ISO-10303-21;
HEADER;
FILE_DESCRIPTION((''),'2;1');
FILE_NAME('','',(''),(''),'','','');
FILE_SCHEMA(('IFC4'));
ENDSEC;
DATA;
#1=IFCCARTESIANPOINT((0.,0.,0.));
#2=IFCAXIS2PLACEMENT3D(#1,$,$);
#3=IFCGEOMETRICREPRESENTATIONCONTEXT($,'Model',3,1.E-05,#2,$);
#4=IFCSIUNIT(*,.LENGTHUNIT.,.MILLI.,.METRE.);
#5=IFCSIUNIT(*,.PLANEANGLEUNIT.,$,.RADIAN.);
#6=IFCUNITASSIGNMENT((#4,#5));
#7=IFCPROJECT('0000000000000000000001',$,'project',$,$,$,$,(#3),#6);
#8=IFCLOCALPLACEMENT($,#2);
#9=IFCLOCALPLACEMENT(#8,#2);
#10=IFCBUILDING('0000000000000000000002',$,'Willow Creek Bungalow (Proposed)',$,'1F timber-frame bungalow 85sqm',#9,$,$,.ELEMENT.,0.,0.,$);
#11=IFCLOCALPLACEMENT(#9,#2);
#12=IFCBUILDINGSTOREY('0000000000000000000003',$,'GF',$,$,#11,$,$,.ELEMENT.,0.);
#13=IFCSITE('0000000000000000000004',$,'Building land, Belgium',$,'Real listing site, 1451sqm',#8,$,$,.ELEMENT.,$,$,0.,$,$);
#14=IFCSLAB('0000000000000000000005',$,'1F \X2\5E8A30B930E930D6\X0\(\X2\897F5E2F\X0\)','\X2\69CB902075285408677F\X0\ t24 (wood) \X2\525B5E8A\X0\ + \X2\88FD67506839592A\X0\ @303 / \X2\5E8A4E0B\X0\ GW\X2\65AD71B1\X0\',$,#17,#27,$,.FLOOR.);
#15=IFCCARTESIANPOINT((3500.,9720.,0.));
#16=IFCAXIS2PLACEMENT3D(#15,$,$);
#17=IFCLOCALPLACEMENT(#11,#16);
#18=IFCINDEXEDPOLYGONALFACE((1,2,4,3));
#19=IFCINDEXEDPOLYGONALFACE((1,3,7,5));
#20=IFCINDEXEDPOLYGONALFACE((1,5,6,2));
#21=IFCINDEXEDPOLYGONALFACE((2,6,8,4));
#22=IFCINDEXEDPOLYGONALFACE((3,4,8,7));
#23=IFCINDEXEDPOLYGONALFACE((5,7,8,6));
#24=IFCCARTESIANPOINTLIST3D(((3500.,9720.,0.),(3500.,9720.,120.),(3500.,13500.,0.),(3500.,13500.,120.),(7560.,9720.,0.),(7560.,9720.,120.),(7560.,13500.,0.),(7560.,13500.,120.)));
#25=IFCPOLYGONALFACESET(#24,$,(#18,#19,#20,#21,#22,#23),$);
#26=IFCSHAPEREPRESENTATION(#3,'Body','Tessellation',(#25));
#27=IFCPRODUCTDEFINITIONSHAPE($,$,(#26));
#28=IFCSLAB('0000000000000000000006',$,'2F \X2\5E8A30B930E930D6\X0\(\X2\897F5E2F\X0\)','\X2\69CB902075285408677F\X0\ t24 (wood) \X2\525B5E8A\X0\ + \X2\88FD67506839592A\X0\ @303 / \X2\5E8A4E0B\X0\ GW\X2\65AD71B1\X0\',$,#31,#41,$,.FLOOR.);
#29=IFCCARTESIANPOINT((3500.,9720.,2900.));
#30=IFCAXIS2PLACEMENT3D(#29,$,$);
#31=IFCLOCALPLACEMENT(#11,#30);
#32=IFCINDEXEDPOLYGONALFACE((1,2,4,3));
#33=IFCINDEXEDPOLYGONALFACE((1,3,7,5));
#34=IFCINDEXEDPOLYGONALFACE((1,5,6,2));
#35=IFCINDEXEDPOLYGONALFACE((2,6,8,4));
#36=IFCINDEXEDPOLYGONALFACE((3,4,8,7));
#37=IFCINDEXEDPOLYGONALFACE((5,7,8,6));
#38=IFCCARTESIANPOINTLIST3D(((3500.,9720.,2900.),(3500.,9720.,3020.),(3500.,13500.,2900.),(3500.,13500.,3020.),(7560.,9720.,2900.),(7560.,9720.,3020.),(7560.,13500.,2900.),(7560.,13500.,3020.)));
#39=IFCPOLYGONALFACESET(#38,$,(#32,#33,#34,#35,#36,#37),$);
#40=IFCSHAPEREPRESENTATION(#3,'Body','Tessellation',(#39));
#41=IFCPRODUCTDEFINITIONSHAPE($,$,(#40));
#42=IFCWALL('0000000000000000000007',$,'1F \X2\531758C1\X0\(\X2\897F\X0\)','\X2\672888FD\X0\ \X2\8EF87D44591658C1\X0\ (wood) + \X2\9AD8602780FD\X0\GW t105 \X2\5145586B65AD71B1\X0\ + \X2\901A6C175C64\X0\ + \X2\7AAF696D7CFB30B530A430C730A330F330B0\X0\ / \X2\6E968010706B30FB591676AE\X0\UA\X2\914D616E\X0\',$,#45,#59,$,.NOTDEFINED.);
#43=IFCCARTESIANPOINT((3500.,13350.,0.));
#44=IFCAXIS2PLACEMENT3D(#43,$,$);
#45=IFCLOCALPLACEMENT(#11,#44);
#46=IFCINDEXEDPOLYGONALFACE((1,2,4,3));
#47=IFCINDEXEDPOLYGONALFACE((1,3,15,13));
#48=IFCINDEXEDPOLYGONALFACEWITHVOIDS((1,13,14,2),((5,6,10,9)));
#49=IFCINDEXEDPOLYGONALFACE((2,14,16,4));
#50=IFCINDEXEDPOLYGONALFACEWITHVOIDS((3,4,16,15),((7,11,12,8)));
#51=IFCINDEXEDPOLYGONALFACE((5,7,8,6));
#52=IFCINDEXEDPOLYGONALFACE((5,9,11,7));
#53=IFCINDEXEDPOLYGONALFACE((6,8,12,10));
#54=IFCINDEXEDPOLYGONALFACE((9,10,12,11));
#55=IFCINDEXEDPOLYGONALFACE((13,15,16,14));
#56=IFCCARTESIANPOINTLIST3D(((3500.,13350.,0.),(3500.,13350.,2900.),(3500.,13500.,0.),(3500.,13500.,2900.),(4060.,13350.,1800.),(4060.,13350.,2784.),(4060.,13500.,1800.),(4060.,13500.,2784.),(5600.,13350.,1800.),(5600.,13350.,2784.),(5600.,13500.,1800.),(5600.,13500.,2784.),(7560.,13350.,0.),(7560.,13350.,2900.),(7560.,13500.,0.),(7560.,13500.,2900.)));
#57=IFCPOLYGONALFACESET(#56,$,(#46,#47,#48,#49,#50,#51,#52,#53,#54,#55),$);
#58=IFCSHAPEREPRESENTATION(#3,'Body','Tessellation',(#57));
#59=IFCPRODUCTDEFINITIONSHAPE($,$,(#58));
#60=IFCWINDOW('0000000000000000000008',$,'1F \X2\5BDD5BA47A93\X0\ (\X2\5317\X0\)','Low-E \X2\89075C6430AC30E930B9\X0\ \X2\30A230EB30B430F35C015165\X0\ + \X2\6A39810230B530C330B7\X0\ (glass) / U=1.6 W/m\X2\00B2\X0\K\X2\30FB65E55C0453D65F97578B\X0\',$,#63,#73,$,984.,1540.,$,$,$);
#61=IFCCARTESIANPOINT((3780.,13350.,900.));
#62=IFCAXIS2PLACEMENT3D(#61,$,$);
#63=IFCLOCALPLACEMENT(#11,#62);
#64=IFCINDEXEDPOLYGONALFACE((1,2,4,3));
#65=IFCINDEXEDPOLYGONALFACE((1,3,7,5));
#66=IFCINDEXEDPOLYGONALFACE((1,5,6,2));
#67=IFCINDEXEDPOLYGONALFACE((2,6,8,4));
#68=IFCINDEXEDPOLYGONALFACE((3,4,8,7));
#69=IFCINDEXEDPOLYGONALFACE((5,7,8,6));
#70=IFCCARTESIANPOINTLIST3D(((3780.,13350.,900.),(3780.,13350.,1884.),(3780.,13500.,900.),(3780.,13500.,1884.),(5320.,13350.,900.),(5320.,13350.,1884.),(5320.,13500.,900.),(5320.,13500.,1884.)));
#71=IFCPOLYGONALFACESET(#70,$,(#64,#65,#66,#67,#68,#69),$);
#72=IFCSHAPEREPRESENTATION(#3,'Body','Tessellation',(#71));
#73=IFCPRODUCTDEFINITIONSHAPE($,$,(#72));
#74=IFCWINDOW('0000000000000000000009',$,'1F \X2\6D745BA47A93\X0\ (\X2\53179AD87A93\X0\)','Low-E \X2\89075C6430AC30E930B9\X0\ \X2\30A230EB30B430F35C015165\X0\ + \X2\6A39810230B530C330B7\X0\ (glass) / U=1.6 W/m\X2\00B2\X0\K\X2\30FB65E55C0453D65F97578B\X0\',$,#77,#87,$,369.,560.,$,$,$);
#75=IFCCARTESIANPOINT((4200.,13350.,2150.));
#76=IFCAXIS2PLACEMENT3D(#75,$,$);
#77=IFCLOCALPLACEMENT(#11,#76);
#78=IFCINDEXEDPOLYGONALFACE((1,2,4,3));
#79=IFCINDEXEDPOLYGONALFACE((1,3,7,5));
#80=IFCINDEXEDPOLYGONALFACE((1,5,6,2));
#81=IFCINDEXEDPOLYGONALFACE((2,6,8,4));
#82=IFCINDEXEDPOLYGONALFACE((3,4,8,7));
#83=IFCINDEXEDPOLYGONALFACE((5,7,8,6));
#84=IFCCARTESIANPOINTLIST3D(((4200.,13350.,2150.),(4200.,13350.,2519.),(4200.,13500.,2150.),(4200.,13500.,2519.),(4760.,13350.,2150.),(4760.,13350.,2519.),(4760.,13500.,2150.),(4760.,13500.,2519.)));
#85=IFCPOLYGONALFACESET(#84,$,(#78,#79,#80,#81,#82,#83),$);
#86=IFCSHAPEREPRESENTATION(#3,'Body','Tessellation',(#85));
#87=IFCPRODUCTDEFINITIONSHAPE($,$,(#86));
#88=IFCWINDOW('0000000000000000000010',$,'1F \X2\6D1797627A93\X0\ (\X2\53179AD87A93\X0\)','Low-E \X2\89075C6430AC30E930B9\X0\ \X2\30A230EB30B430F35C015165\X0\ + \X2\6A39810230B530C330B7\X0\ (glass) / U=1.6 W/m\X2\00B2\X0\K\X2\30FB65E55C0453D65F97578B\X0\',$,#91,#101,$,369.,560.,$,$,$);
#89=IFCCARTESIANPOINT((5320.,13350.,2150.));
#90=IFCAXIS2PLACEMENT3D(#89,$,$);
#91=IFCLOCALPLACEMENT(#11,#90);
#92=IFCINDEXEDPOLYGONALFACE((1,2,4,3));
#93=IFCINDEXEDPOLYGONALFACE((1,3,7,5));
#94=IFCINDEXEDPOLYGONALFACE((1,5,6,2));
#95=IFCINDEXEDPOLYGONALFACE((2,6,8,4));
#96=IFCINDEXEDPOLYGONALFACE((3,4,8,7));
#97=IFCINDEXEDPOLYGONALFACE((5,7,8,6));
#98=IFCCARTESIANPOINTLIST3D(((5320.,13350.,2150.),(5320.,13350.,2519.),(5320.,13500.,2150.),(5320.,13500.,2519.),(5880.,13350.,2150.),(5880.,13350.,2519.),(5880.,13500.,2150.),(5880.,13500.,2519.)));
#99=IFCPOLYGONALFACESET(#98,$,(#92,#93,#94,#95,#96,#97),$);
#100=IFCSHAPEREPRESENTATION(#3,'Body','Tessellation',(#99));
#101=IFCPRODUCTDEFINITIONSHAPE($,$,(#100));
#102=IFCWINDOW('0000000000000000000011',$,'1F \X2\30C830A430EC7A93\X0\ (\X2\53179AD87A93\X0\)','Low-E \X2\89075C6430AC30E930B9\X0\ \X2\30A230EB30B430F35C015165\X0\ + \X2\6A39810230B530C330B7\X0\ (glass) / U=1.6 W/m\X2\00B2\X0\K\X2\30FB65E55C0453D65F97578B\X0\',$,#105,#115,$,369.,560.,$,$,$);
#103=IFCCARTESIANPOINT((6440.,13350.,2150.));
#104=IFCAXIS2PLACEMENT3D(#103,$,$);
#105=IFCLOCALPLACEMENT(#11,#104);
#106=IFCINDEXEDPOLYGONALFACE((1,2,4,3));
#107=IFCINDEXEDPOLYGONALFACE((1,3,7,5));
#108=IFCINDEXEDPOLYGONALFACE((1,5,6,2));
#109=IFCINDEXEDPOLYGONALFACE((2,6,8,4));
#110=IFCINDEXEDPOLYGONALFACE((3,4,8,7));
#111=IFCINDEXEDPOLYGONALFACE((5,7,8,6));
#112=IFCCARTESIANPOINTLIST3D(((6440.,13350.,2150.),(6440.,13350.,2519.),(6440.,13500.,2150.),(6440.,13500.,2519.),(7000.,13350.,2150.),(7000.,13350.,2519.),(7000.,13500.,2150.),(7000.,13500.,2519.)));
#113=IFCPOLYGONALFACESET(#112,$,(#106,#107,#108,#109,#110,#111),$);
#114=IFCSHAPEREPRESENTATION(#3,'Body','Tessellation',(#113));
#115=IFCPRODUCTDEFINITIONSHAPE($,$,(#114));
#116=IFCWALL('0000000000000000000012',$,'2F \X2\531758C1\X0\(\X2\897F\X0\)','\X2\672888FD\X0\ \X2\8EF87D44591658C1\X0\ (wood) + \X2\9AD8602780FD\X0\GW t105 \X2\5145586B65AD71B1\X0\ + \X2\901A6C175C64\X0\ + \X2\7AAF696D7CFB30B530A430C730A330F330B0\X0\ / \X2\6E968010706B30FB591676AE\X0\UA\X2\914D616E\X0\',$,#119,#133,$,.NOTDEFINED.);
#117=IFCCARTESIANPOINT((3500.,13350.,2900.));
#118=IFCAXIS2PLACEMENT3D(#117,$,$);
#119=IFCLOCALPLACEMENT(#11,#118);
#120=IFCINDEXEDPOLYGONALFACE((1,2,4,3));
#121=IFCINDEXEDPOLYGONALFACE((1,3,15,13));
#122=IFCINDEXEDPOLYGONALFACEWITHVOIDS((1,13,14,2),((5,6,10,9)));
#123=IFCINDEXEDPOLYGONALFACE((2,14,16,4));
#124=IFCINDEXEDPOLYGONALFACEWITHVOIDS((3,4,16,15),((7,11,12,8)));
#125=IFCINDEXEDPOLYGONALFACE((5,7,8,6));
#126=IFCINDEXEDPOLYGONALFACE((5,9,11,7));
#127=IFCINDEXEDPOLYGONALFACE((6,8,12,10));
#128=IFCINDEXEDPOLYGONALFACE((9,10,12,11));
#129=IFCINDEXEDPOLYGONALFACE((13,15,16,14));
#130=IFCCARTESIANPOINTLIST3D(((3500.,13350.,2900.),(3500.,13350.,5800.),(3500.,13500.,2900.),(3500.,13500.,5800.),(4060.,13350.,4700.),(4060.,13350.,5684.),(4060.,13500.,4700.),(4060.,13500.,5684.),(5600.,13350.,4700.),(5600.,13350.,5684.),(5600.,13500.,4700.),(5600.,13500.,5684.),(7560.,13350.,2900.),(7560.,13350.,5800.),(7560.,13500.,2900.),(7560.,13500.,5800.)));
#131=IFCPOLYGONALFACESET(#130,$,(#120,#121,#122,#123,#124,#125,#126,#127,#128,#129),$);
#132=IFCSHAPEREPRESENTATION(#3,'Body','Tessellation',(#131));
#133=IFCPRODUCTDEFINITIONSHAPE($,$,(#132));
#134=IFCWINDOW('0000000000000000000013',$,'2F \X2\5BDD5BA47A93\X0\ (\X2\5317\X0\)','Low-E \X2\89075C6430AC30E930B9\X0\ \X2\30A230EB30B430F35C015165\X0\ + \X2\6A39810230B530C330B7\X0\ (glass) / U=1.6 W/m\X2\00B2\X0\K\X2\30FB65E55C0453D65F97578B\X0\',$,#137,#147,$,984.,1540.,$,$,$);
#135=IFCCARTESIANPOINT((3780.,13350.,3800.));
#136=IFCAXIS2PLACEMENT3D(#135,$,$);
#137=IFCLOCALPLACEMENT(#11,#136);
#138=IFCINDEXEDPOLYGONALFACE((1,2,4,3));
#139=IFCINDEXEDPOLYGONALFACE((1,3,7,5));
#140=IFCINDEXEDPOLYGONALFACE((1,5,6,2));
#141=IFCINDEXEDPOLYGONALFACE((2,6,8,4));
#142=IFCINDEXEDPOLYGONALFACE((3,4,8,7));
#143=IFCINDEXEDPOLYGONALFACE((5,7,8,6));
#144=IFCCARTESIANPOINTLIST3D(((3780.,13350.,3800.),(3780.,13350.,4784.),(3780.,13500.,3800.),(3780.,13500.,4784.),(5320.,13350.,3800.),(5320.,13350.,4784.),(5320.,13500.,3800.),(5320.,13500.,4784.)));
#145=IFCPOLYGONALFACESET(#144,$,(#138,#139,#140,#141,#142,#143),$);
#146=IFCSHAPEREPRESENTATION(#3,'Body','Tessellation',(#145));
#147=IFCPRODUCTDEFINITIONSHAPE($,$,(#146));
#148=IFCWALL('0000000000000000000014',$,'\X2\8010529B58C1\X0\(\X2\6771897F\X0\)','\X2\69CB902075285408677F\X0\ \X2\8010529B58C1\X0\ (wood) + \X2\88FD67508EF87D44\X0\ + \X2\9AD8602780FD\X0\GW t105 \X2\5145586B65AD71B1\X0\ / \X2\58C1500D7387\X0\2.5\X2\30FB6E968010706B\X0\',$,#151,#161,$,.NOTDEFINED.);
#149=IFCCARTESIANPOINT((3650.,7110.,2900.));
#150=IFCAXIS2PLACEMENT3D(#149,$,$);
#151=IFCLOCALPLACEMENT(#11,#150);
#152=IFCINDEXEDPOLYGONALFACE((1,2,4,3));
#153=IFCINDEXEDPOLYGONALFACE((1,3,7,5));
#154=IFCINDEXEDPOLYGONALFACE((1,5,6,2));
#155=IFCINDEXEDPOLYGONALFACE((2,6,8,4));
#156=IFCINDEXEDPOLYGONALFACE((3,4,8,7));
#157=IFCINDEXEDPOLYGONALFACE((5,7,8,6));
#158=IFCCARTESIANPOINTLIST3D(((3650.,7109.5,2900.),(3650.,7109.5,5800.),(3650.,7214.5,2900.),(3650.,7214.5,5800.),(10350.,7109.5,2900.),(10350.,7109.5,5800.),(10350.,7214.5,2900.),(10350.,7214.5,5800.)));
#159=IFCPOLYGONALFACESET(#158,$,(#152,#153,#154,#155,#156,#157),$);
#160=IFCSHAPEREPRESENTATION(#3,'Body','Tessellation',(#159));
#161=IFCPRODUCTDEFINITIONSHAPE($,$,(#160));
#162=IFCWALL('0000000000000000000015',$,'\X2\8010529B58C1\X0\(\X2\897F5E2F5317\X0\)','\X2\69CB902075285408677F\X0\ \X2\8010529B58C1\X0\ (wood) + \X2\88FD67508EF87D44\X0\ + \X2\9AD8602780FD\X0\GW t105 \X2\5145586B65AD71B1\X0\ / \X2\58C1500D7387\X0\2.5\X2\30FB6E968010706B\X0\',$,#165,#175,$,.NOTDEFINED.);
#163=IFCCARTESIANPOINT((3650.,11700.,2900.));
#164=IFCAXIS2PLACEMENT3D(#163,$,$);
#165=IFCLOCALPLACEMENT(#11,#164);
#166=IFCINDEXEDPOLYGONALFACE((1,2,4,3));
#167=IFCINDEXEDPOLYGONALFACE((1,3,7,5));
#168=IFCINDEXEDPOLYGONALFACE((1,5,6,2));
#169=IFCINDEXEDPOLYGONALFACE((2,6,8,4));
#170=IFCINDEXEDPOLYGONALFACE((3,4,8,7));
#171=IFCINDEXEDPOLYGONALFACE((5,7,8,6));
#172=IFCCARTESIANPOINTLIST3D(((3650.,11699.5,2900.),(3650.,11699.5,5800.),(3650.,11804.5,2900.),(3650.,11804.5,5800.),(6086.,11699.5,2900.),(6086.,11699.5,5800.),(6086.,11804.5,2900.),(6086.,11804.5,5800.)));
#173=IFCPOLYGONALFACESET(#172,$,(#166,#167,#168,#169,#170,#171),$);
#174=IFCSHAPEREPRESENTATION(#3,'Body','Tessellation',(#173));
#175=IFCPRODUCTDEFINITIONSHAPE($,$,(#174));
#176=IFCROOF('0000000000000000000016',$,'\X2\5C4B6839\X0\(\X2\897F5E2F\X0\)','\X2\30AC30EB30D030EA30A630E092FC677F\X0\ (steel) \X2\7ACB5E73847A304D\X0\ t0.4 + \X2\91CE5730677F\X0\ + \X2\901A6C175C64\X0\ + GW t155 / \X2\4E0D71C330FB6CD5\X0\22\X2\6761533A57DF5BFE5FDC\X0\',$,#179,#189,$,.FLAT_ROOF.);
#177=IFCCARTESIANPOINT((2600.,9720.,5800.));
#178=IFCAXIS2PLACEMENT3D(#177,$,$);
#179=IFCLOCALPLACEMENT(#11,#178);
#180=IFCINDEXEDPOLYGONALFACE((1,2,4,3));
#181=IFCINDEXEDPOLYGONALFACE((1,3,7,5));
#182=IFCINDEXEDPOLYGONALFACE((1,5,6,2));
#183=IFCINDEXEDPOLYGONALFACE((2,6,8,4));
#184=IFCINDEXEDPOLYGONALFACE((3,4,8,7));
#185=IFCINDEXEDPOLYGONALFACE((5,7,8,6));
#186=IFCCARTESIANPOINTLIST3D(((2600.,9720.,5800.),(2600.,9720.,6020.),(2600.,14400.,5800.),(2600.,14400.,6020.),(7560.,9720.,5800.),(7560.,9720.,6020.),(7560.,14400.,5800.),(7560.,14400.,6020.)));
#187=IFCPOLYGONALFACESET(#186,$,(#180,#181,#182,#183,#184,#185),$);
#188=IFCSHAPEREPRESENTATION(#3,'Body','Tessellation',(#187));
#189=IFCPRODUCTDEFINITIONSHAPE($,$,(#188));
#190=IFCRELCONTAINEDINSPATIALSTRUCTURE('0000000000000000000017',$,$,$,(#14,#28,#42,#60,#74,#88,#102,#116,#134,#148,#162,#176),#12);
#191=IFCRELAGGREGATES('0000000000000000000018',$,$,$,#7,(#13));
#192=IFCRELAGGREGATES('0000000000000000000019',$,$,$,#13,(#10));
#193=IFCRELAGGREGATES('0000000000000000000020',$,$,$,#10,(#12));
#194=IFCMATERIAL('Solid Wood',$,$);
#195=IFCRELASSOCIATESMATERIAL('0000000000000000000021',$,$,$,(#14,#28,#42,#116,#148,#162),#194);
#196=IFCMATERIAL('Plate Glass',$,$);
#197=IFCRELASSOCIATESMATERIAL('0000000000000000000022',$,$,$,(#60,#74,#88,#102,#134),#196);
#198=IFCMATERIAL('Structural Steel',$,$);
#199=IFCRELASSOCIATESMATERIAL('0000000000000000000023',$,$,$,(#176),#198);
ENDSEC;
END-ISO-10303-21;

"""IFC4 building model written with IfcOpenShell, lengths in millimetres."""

from ifc_helpers import new_model, si_unit, frame, frame_2d, origin, place, context, project, spatial, rectangle, extrude, material, element, fill, save


model = new_model("IFC4")

# Units and contexts
model_context = context("Model", 3, precision=1e-05, world=origin())
ifc_project = project(units=[si_unit("LENGTHUNIT", "METRE", prefix="MILLI"), si_unit("PLANEANGLEUNIT", "RADIAN")], contexts=[model_context])

# Site, building, storey
site_placement = place(None, origin())
site = spatial("IfcSite", under=ifc_project, at=site_placement, Name="Building land, Belgium", ObjectType="Real listing site, 1451sqm", CompositionType="ELEMENT", RefElevation=0.0)
building_placement = place(site_placement, origin())
building = spatial("IfcBuilding", under=site, at=building_placement, Name="Willow Creek Bungalow (Proposed)", ObjectType="1F timber-frame bungalow 85sqm", CompositionType="ELEMENT", ElevationOfRefHeight=0.0, ElevationOfTerrain=0.0)
storey_placement = place(building_placement, origin())
storey = spatial("IfcBuildingStorey", under=building, at=storey_placement, Name="GF", CompositionType="ELEMENT", Elevation=0.0)

# Slabs
ifc_material_1 = material(Name="Solid Wood")
slab_1_placement = place(storey_placement, frame((3500.0, 9720.0, 0.0)))
element("IfcSlab", 1, at=slab_1_placement, inside=storey, material=ifc_material_1, Name="1F 床スラブ(西帯)", Description="構造用合板 t24 (wood) 剛床 + 製材根太 @303 / 床下 GW断熱", PredefinedType="FLOOR", context=model_context, shape_type="SweptSolid", body=[
    extrude(rectangle(XDim=4060.0, YDim=3780.0, at=frame_2d((2030.0, 1890.0))), frame((3500.0, 9720.0, 0.0)), (0.0, 0.0, 1.0), 120.0),
])
slab_2_placement = place(storey_placement, frame((3500.0, 9720.0, 2900.0)))
element("IfcSlab", 2, at=slab_2_placement, inside=storey, material=ifc_material_1, Name="2F 床スラブ(西帯)", Description="構造用合板 t24 (wood) 剛床 + 製材根太 @303 / 床下 GW断熱", PredefinedType="FLOOR", context=model_context, shape_type="SweptSolid", body=[
    extrude(rectangle(XDim=4060.0, YDim=3780.0, at=frame_2d((2030.0, 1890.0))), frame((3500.0, 9720.0, 2900.0)), (0.0, 0.0, 1.0), 120.0),
])

# Wall, openings, windows
wall_1_placement = place(storey_placement, frame((3500.0, 13350.0, 0.0)))
wall_1 = element("IfcWall", 3, at=wall_1_placement, inside=storey, material=ifc_material_1, Name="1F 北壁(西)", Description="木製 軸組外壁 (wood) + 高性能GW t105 充填断熱 + 通気層 + 窯業系サイディング / 準耐火・外皮UA配慮", PredefinedType="NOTDEFINED", context=model_context, shape_type="SweptSolid", body=[
    extrude(rectangle(XDim=4060.0, YDim=150.0, at=frame_2d((2030.0, 75.0))), frame((3500.0, 13350.0, 0.0)), (0.0, 0.0, 1.0), 2900.0),
])
opening_1_placement = place(storey_placement, frame((3780.0, 13350.0, 900.0)))
opening_1 = element("IfcOpeningElement", 4, at=opening_1_placement, cuts=wall_1, PredefinedType="NOTDEFINED", context=model_context, shape_type="SweptSolid", body=[
    extrude(rectangle(XDim=1540.0, YDim=150.0, at=frame_2d((770.0, 75.0))), frame((3780.0, 13350.0, 900.0)), (0.0, 0.0, 1.0), 984.0),
])
opening_2_placement = place(storey_placement, frame((4200.0, 13350.0, 2150.0)))
opening_2 = element("IfcOpeningElement", 5, at=opening_2_placement, cuts=wall_1, PredefinedType="NOTDEFINED", context=model_context, shape_type="SweptSolid", body=[
    extrude(rectangle(XDim=560.0, YDim=150.0, at=frame_2d((280.0, 75.0))), frame((4200.0, 13350.0, 2150.0)), (0.0, 0.0, 1.0), 369.0),
])
opening_3_placement = place(storey_placement, frame((5320.0, 13350.0, 2150.0)))
opening_3 = element("IfcOpeningElement", 6, at=opening_3_placement, cuts=wall_1, PredefinedType="NOTDEFINED", context=model_context, shape_type="SweptSolid", body=[
    extrude(rectangle(XDim=560.0, YDim=150.0, at=frame_2d((280.0, 75.0))), frame((5320.0, 13350.0, 2150.0)), (0.0, 0.0, 1.0), 369.0),
])
opening_4_placement = place(storey_placement, frame((6440.0, 13350.0, 2150.0)))
opening_4 = element("IfcOpeningElement", 7, at=opening_4_placement, cuts=wall_1, PredefinedType="NOTDEFINED", context=model_context, shape_type="SweptSolid", body=[
    extrude(rectangle(XDim=560.0, YDim=150.0, at=frame_2d((280.0, 75.0))), frame((6440.0, 13350.0, 2150.0)), (0.0, 0.0, 1.0), 369.0),
])
ifc_material_2 = material(Name="Plate Glass")
window_1_placement = place(storey_placement, frame((3780.0, 13350.0, 900.0)))
window_1 = element("IfcWindow", 8, at=window_1_placement, inside=storey, material=ifc_material_2, Name="1F 寝室窓 (北)", Description="Low-E 複層ガラス アルゴン封入 + 樹脂サッシ (glass) / U=1.6 W/m²K・日射取得型", OverallHeight=984.0, OverallWidth=1540.0, context=model_context, shape_type="SweptSolid", body=[
    extrude(rectangle(XDim=1540.0, YDim=150.0, at=frame_2d((770.0, 75.0))), frame((3780.0, 13350.0, 900.0)), (0.0, 0.0, 1.0), 984.0),
])
fill(opening_1, window_1)
window_2_placement = place(storey_placement, frame((4200.0, 13350.0, 2150.0)))
window_2 = element("IfcWindow", 9, at=window_2_placement, inside=storey, material=ifc_material_2, Name="1F 浴室窓 (北高窓)", Description="Low-E 複層ガラス アルゴン封入 + 樹脂サッシ (glass) / U=1.6 W/m²K・日射取得型", OverallHeight=369.0, OverallWidth=560.0, context=model_context, shape_type="SweptSolid", body=[
    extrude(rectangle(XDim=560.0, YDim=150.0, at=frame_2d((280.0, 75.0))), frame((4200.0, 13350.0, 2150.0)), (0.0, 0.0, 1.0), 369.0),
])
fill(opening_2, window_2)
window_3_placement = place(storey_placement, frame((5320.0, 13350.0, 2150.0)))
window_3 = element("IfcWindow", 10, at=window_3_placement, inside=storey, material=ifc_material_2, Name="1F 洗面窓 (北高窓)", Description="Low-E 複層ガラス アルゴン封入 + 樹脂サッシ (glass) / U=1.6 W/m²K・日射取得型", OverallHeight=369.0, OverallWidth=560.0, context=model_context, shape_type="SweptSolid", body=[
    extrude(rectangle(XDim=560.0, YDim=150.0, at=frame_2d((280.0, 75.0))), frame((5320.0, 13350.0, 2150.0)), (0.0, 0.0, 1.0), 369.0),
])
fill(opening_3, window_3)
window_4_placement = place(storey_placement, frame((6440.0, 13350.0, 2150.0)))
window_4 = element("IfcWindow", 11, at=window_4_placement, inside=storey, material=ifc_material_2, Name="1F トイレ窓 (北高窓)", Description="Low-E 複層ガラス アルゴン封入 + 樹脂サッシ (glass) / U=1.6 W/m²K・日射取得型", OverallHeight=369.0, OverallWidth=560.0, context=model_context, shape_type="SweptSolid", body=[
    extrude(rectangle(XDim=560.0, YDim=150.0, at=frame_2d((280.0, 75.0))), frame((6440.0, 13350.0, 2150.0)), (0.0, 0.0, 1.0), 369.0),
])
fill(opening_4, window_4)

# Wall, opening, window
wall_2_placement = place(storey_placement, frame((3500.0, 13350.0, 2900.0)))
wall_2 = element("IfcWall", 12, at=wall_2_placement, inside=storey, material=ifc_material_1, Name="2F 北壁(西)", Description="木製 軸組外壁 (wood) + 高性能GW t105 充填断熱 + 通気層 + 窯業系サイディング / 準耐火・外皮UA配慮", PredefinedType="NOTDEFINED", context=model_context, shape_type="SweptSolid", body=[
    extrude(rectangle(XDim=4060.0, YDim=150.0, at=frame_2d((2030.0, 75.0))), frame((3500.0, 13350.0, 2900.0)), (0.0, 0.0, 1.0), 2900.0),
])
opening_5_placement = place(storey_placement, frame((3780.0, 13350.0, 3800.0)))
opening_5 = element("IfcOpeningElement", 13, at=opening_5_placement, cuts=wall_2, PredefinedType="NOTDEFINED", context=model_context, shape_type="SweptSolid", body=[
    extrude(rectangle(XDim=1540.0, YDim=150.0, at=frame_2d((770.0, 75.0))), frame((3780.0, 13350.0, 3800.0)), (0.0, 0.0, 1.0), 984.0),
])
window_5_placement = place(storey_placement, frame((3780.0, 13350.0, 3800.0)))
window_5 = element("IfcWindow", 14, at=window_5_placement, inside=storey, material=ifc_material_2, Name="2F 寝室窓 (北)", Description="Low-E 複層ガラス アルゴン封入 + 樹脂サッシ (glass) / U=1.6 W/m²K・日射取得型", OverallHeight=984.0, OverallWidth=1540.0, context=model_context, shape_type="SweptSolid", body=[
    extrude(rectangle(XDim=1540.0, YDim=150.0, at=frame_2d((770.0, 75.0))), frame((3780.0, 13350.0, 3800.0)), (0.0, 0.0, 1.0), 984.0),
])
fill(opening_5, window_5)

# Walls
wall_3_placement = place(storey_placement, frame((3650.0, 7110.0, 2900.0)))
element("IfcWall", 15, at=wall_3_placement, inside=storey, material=ifc_material_1, Name="耐力壁(東西)", Description="構造用合板 耐力壁 (wood) + 製材軸組 + 高性能GW t105 充填断熱 / 壁倍率2.5・準耐火", PredefinedType="NOTDEFINED", context=model_context, shape_type="SweptSolid", body=[
    extrude(rectangle(XDim=6700.0, YDim=105.0, at=frame_2d((3350.0, 52.0))), frame((3650.0, 7110.0, 2900.0)), (0.0, 0.0, 1.0), 2900.0),
])
wall_4_placement = place(storey_placement, frame((3650.0, 11700.0, 2900.0)))
element("IfcWall", 16, at=wall_4_placement, inside=storey, material=ifc_material_1, Name="耐力壁(西帯北)", Description="構造用合板 耐力壁 (wood) + 製材軸組 + 高性能GW t105 充填断熱 / 壁倍率2.5・準耐火", PredefinedType="NOTDEFINED", context=model_context, shape_type="SweptSolid", body=[
    extrude(rectangle(XDim=2436.0, YDim=105.0, at=frame_2d((1218.0, 52.0))), frame((3650.0, 11700.0, 2900.0)), (0.0, 0.0, 1.0), 2900.0),
])

# Roof
ifc_material_3 = material(Name="Structural Steel")
for number, where, name in (
    (17, (2600.0, 9720.0, 5800.0), "屋根(西帯)"),
):
    element("IfcRoof", number, at=place(storey_placement, frame(where)), inside=storey, material=ifc_material_3, Name=name, Description="ガルバリウム鋼板 (steel) 立平葺き t0.4 + 野地板 + 通気層 + GW t155 / 不燃・法22条区域対応", PredefinedType="FLAT_ROOF", context=model_context, shape_type="SweptSolid", body=[
        extrude(rectangle(XDim=4960.0, YDim=4680.0, at=frame_2d((2480.0, 2340.0))), frame((2600.0, 9720.0, 5800.0)), (0.0, 0.0, 1.0), 220.0),
    ])

save(model, "model.ifc")
